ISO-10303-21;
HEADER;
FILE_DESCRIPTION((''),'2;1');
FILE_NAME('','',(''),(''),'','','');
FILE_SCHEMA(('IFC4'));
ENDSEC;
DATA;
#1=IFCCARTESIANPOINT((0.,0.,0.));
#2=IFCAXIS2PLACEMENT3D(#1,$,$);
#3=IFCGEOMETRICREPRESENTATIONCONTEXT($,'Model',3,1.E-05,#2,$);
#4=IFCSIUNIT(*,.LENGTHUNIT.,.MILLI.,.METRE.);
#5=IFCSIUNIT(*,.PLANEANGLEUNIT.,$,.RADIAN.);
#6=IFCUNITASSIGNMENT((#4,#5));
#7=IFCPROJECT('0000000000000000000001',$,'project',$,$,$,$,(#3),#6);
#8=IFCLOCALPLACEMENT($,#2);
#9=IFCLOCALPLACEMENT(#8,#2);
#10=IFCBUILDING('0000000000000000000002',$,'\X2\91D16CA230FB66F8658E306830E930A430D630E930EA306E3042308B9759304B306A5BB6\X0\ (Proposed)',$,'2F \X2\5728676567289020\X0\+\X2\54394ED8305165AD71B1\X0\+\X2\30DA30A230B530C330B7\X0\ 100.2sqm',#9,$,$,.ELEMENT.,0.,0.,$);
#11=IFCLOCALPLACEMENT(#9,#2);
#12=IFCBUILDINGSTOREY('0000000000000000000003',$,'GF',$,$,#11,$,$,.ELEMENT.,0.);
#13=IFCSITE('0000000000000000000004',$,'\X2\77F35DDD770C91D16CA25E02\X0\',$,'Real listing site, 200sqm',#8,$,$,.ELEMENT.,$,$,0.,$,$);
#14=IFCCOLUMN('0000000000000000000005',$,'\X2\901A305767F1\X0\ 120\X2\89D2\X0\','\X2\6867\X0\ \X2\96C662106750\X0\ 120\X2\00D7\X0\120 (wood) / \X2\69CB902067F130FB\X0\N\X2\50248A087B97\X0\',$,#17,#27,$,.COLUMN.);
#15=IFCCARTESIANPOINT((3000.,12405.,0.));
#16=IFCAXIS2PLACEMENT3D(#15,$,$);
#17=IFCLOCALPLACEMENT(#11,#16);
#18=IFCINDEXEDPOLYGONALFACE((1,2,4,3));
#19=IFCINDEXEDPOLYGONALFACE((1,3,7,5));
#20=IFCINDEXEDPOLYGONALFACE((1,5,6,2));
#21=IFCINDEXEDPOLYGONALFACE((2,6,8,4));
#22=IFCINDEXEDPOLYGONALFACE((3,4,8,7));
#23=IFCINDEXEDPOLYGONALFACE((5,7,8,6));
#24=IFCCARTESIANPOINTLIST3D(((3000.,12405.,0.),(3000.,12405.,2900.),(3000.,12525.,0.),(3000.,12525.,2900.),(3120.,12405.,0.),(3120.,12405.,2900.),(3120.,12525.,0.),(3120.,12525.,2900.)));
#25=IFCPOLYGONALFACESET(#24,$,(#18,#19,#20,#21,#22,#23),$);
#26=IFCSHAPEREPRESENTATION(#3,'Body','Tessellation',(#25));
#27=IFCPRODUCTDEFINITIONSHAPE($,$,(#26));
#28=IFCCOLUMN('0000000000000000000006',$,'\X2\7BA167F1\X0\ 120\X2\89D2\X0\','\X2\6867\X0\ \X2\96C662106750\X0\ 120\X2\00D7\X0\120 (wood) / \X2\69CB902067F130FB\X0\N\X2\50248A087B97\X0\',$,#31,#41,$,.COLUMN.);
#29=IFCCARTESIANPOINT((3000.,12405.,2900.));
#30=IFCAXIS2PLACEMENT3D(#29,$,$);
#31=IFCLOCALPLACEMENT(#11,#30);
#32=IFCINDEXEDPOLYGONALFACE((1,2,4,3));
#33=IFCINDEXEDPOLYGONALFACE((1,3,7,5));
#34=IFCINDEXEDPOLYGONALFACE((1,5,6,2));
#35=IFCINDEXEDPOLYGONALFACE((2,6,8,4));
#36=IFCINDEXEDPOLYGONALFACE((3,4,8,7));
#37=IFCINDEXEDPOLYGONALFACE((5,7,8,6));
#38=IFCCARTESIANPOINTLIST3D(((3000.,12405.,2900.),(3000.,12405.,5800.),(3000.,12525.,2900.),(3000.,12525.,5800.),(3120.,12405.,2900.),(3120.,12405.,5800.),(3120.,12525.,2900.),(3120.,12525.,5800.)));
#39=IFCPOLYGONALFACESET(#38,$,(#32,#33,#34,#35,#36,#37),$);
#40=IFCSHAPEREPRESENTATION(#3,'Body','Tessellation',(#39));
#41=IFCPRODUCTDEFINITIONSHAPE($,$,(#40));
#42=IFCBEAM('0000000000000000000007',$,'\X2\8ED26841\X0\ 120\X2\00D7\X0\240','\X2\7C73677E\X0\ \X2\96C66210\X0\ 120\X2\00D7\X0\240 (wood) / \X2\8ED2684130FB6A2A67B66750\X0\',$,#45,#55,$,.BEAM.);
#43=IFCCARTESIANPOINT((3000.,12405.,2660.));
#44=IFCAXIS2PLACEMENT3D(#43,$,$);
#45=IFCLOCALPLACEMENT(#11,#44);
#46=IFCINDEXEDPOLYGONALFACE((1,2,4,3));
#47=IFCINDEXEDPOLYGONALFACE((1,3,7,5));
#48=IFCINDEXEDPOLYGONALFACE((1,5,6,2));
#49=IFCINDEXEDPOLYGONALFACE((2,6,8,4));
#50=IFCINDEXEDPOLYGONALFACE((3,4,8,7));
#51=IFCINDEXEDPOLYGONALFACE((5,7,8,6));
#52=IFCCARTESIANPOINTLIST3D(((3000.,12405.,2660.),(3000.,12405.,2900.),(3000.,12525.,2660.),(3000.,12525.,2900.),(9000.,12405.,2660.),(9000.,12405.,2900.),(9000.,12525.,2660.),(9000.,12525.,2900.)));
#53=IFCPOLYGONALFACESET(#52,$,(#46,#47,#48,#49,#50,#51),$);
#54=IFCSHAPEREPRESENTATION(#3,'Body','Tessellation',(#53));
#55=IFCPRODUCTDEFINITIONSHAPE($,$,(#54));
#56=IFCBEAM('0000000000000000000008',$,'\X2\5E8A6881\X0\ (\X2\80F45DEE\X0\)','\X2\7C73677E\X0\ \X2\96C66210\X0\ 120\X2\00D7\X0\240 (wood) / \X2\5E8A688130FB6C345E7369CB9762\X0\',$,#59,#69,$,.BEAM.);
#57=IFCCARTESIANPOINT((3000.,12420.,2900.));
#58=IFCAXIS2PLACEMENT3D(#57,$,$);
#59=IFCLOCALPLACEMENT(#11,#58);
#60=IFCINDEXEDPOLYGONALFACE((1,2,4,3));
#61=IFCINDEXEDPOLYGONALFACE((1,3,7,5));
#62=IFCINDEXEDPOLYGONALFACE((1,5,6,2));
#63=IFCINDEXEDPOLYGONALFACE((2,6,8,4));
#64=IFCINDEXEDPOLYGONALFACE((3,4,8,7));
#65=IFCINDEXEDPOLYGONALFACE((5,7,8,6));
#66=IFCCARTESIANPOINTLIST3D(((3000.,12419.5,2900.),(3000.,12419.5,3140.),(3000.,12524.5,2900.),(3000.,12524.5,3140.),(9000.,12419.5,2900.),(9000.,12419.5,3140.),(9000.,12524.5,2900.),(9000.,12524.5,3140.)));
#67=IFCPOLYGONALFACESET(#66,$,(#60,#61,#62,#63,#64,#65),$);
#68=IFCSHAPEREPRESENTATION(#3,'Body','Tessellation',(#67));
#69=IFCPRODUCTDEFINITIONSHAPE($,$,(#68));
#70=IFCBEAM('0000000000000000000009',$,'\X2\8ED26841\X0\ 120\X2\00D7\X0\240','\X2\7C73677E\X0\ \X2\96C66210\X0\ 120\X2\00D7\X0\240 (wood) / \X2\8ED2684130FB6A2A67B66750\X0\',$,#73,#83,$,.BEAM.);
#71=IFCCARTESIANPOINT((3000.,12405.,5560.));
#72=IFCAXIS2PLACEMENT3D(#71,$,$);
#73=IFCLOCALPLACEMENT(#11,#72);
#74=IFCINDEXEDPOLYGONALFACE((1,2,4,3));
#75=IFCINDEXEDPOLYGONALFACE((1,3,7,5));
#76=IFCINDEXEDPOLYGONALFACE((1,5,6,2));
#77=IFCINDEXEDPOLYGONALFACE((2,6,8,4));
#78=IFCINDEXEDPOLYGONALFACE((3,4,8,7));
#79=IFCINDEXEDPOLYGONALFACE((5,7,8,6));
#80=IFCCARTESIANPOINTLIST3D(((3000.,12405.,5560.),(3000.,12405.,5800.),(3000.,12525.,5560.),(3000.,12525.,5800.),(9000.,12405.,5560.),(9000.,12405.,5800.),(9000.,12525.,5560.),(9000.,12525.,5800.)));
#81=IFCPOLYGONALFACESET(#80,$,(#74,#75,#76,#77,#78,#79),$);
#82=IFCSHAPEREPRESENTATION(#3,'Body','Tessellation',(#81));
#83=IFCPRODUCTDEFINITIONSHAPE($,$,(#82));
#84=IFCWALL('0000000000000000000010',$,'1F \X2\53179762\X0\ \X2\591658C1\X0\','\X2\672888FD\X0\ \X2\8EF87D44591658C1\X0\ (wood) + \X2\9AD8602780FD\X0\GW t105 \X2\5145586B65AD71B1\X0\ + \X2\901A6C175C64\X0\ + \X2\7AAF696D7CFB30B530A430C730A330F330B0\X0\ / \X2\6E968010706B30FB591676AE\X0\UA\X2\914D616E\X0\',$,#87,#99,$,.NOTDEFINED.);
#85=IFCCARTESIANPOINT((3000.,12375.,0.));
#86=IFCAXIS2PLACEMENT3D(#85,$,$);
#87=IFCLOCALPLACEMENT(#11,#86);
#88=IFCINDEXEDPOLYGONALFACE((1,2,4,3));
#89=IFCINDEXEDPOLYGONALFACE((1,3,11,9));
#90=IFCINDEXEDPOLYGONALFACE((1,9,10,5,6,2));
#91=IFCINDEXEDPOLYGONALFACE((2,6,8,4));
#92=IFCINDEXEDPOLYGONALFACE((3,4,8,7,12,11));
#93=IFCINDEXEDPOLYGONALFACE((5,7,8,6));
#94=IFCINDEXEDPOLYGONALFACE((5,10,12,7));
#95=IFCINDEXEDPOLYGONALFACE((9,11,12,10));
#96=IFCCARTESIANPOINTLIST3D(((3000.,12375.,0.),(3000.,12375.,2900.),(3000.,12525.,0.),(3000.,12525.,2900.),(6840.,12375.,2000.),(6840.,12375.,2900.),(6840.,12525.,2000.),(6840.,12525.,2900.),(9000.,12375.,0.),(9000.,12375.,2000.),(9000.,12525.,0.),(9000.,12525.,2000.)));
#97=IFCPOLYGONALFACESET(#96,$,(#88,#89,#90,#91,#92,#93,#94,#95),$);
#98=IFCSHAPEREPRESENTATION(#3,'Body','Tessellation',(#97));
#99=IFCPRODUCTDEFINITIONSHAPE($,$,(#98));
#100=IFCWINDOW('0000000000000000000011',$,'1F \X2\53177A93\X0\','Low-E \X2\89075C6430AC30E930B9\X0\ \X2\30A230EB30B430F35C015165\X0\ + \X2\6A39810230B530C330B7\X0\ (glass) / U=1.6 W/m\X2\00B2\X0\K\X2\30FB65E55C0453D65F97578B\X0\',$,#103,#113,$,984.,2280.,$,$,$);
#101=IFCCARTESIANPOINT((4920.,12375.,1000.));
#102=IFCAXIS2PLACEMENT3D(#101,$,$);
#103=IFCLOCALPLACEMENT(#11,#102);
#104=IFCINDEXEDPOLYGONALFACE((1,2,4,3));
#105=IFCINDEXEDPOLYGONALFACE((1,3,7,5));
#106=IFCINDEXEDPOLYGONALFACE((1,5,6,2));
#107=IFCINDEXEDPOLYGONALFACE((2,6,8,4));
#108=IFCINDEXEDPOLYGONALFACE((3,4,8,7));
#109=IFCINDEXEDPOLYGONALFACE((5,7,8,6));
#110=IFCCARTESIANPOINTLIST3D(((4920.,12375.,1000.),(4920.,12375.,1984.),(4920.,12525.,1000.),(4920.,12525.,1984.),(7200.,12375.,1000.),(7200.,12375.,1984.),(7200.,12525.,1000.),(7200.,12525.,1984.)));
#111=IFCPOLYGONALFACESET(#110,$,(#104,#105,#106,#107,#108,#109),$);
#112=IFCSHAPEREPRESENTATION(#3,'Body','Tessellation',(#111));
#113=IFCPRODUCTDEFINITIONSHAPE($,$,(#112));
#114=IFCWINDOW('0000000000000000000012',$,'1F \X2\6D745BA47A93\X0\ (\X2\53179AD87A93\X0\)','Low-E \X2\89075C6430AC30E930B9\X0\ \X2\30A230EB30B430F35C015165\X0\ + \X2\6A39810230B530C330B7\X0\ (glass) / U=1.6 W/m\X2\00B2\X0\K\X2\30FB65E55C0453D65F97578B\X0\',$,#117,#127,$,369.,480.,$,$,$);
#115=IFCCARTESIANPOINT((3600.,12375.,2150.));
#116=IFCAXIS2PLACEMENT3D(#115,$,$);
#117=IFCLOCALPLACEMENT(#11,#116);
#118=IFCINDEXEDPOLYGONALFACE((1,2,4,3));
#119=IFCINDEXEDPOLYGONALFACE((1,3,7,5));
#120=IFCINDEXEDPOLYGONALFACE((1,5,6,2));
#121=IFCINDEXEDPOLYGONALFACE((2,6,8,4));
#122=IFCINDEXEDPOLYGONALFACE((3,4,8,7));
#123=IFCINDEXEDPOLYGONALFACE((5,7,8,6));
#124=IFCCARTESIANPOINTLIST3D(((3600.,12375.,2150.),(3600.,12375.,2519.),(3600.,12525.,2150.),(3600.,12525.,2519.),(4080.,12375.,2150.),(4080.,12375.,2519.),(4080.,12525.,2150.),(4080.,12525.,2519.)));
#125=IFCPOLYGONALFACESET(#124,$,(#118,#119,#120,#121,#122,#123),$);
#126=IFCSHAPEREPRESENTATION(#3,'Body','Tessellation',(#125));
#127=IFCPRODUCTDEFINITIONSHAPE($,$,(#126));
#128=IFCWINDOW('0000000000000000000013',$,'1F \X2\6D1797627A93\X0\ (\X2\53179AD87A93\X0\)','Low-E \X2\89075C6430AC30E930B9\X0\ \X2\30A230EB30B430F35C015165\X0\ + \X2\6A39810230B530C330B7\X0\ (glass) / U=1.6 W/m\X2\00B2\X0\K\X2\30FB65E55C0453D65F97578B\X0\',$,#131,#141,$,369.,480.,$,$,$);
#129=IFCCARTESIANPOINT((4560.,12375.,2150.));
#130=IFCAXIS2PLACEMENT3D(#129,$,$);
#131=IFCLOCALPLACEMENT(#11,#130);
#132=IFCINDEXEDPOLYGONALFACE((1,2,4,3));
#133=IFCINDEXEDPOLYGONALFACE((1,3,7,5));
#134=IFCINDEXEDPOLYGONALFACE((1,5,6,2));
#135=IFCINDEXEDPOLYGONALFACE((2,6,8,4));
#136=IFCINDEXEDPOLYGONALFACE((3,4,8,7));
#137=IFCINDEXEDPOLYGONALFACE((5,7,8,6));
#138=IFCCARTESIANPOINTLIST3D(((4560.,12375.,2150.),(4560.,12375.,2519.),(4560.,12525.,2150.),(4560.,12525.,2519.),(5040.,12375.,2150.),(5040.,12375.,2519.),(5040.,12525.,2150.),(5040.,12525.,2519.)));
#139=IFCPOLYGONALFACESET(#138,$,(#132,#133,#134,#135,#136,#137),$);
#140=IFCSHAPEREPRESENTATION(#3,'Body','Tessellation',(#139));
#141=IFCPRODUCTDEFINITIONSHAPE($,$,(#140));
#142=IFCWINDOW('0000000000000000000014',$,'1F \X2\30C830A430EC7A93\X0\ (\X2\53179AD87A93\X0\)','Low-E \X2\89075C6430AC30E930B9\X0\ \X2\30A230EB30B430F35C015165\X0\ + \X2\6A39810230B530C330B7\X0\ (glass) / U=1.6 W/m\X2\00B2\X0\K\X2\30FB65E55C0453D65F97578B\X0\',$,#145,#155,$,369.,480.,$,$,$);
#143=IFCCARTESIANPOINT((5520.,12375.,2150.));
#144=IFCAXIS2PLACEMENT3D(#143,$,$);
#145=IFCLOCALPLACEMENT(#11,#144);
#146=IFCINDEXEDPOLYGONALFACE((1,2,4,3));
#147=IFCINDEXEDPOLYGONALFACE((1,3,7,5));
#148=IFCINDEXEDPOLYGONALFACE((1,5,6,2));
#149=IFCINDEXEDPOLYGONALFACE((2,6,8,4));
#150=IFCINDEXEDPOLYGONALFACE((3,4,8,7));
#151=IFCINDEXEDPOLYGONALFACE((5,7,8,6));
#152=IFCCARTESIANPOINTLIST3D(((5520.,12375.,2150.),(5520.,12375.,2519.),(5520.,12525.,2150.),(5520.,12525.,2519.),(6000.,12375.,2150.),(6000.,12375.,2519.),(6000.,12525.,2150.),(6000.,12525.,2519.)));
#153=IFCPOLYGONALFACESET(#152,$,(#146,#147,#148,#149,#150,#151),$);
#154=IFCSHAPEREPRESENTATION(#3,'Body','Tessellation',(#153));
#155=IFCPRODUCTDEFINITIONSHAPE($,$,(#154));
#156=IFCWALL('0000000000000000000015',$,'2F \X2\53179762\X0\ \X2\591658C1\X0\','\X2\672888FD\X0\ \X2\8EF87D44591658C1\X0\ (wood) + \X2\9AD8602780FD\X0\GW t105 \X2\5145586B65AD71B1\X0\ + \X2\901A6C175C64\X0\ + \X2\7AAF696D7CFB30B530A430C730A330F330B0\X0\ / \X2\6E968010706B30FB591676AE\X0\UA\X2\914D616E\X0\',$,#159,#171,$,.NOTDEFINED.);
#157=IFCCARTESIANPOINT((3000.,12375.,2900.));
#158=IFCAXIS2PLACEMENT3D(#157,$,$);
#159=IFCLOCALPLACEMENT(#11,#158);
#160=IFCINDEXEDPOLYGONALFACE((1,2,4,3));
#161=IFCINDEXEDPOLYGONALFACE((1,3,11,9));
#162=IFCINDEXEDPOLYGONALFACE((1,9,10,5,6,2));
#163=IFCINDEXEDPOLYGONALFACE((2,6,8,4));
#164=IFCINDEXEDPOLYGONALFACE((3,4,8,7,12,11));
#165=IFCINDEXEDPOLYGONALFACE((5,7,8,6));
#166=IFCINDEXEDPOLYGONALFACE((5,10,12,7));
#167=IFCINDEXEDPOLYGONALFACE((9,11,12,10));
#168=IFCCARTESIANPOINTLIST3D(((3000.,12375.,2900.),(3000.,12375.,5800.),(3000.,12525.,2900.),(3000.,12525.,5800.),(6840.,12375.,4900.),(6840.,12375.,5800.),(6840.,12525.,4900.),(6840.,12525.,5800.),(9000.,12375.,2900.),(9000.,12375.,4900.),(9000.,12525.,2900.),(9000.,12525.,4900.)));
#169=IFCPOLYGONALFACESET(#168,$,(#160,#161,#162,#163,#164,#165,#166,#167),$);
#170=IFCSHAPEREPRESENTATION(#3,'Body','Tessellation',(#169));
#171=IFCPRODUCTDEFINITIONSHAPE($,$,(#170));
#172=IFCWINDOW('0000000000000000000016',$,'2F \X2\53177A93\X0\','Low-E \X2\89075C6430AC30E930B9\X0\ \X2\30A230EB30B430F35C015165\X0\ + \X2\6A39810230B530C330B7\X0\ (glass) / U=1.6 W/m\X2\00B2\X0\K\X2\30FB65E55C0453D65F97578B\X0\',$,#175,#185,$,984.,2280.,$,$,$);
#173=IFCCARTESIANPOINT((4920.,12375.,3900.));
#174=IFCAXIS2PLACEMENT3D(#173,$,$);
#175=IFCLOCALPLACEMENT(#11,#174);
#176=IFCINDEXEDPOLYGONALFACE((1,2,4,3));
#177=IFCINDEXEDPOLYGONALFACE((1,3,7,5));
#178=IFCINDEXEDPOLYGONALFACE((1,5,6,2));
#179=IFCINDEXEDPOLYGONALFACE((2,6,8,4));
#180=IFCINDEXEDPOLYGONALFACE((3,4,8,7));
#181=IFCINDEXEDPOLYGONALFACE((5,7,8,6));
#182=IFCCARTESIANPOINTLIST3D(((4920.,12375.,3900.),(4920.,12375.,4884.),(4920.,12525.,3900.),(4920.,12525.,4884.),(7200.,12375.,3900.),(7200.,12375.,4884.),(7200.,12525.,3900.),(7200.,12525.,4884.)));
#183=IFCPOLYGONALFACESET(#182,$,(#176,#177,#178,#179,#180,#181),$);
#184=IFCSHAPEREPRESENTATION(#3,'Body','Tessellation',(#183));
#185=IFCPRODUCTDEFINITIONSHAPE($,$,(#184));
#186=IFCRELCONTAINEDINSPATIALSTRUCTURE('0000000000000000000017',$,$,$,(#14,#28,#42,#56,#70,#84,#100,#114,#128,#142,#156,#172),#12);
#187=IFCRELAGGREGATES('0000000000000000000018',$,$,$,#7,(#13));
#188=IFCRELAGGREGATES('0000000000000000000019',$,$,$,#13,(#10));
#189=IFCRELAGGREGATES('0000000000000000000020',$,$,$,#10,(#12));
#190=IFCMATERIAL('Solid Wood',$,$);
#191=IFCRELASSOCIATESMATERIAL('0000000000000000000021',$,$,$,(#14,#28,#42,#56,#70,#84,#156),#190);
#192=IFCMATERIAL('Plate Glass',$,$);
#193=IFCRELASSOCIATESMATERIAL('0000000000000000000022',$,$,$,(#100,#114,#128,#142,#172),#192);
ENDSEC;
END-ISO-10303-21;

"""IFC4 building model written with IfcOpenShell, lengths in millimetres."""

from ifc_helpers import new_model, si_unit, frame, frame_2d, origin, place, context, project, spatial, rectangle, extrude, material, element, fill, save


model = new_model("IFC4")

# Units and contexts
model_context = context("Model", 3, precision=1e-05, world=origin())
ifc_project = project(units=[si_unit("LENGTHUNIT", "METRE", prefix="MILLI"), si_unit("PLANEANGLEUNIT", "RADIAN")], contexts=[model_context])

# Site, building, storey
site_placement = place(None, origin())
site = spatial("IfcSite", under=ifc_project, at=site_placement, Name="石川県金沢市", ObjectType="Real listing site, 200sqm", CompositionType="ELEMENT", RefElevation=0.0)
building_placement = place(site_placement, origin())
building = spatial("IfcBuilding", under=site, at=building_placement, Name="金沢・書斎とライブラリのある静かな家 (Proposed)", ObjectType="2F 在来木造+吹付け断熱+ペアサッシ 100.2sqm", CompositionType="ELEMENT", ElevationOfRefHeight=0.0, ElevationOfTerrain=0.0)
storey_placement = place(building_placement, origin())
storey = spatial("IfcBuildingStorey", under=building, at=storey_placement, Name="GF", CompositionType="ELEMENT", Elevation=0.0)

# Columns
ifc_material_1 = material(Name="Solid Wood")
column_1_placement = place(storey_placement, frame((3000.0, 12405.0, 0.0)))
element("IfcColumn", 1, at=column_1_placement, inside=storey, material=ifc_material_1, Name="通し柱 120角", Description="桧 集成材 120×120 (wood) / 構造柱・N値計算", PredefinedType="COLUMN", context=model_context, shape_type="SweptSolid", body=[
    extrude(rectangle(XDim=120.0, YDim=120.0, at=frame_2d((60.0, 60.0))), frame((3000.0, 12405.0, 0.0)), (0.0, 0.0, 1.0), 2900.0),
])
column_2_placement = place(storey_placement, frame((3000.0, 12405.0, 2900.0)))
element("IfcColumn", 2, at=column_2_placement, inside=storey, material=ifc_material_1, Name="管柱 120角", Description="桧 集成材 120×120 (wood) / 構造柱・N値計算", PredefinedType="COLUMN", context=model_context, shape_type="SweptSolid", body=[
    extrude(rectangle(XDim=120.0, YDim=120.0, at=frame_2d((60.0, 60.0))), frame((3000.0, 12405.0, 2900.0)), (0.0, 0.0, 1.0), 2900.0),
])

# Beams
beam_1_placement = place(storey_placement, frame((3000.0, 12405.0, 2660.0)))
element("IfcBeam", 3, at=beam_1_placement, inside=storey, material=ifc_material_1, Name="軒桁 120×240", Description="米松 集成 120×240 (wood) / 軒桁・横架材", PredefinedType="BEAM", context=model_context, shape_type="SweptSolid", body=[
    extrude(rectangle(XDim=6000.0, YDim=120.0, at=frame_2d((3000.0, 60.0))), frame((3000.0, 12405.0, 2660.0)), (0.0, 0.0, 1.0), 240.0),
])
beam_2_placement = place(storey_placement, frame((3000.0, 12420.0, 2900.0)))
element("IfcBeam", 4, at=beam_2_placement, inside=storey, material=ifc_material_1, Name="床梁 (胴差)", Description="米松 集成 120×240 (wood) / 床梁・水平構面", PredefinedType="BEAM", context=model_context, shape_type="SweptSolid", body=[
    extrude(rectangle(XDim=6000.0, YDim=105.0, at=frame_2d((3000.0, 52.0))), frame((3000.0, 12420.0, 2900.0)), (0.0, 0.0, 1.0), 240.0),
])
beam_3_placement = place(storey_placement, frame((3000.0, 12405.0, 5560.0)))
element("IfcBeam", 5, at=beam_3_placement, inside=storey, material=ifc_material_1, Name="軒桁 120×240", Description="米松 集成 120×240 (wood) / 軒桁・横架材", PredefinedType="BEAM", context=model_context, shape_type="SweptSolid", body=[
    extrude(rectangle(XDim=6000.0, YDim=120.0, at=frame_2d((3000.0, 60.0))), frame((3000.0, 12405.0, 5560.0)), (0.0, 0.0, 1.0), 240.0),
])

# Wall, openings, windows
wall_1_placement = place(storey_placement, frame((3000.0, 12375.0, 0.0)))
wall_1 = element("IfcWall", 6, at=wall_1_placement, inside=storey, material=ifc_material_1, Name="1F 北面 外壁", Description="木製 軸組外壁 (wood) + 高性能GW t105 充填断熱 + 通気層 + 窯業系サイディング / 準耐火・外皮UA配慮", PredefinedType="NOTDEFINED", context=model_context, shape_type="SweptSolid", body=[
    extrude(rectangle(XDim=6000.0, YDim=150.0, at=frame_2d((3000.0, 75.0))), frame((3000.0, 12375.0, 0.0)), (0.0, 0.0, 1.0), 2900.0),
])
opening_1_placement = place(storey_placement, frame((4920.0, 12375.0, 1000.0)))
opening_1 = element("IfcOpeningElement", 7, at=opening_1_placement, cuts=wall_1, PredefinedType="NOTDEFINED", context=model_context, shape_type="SweptSolid", body=[
    extrude(rectangle(XDim=2280.0, YDim=150.0, at=frame_2d((1140.0, 75.0))), frame((4920.0, 12375.0, 1000.0)), (0.0, 0.0, 1.0), 984.0),
])
opening_2_placement = place(storey_placement, frame((3600.0, 12375.0, 2150.0)))
opening_2 = element("IfcOpeningElement", 8, at=opening_2_placement, cuts=wall_1, PredefinedType="NOTDEFINED", context=model_context, shape_type="SweptSolid", body=[
    extrude(rectangle(XDim=480.0, YDim=150.0, at=frame_2d((240.0, 75.0))), frame((3600.0, 12375.0, 2150.0)), (0.0, 0.0, 1.0), 369.0),
])
opening_3_placement = place(storey_placement, frame((4560.0, 12375.0, 2150.0)))
opening_3 = element("IfcOpeningElement", 9, at=opening_3_placement, cuts=wall_1, PredefinedType="NOTDEFINED", context=model_context, shape_type="SweptSolid", body=[
    extrude(rectangle(XDim=480.0, YDim=150.0, at=frame_2d((240.0, 75.0))), frame((4560.0, 12375.0, 2150.0)), (0.0, 0.0, 1.0), 369.0),
])
opening_4_placement = place(storey_placement, frame((5520.0, 12375.0, 2150.0)))
opening_4 = element("IfcOpeningElement", 10, at=opening_4_placement, cuts=wall_1, PredefinedType="NOTDEFINED", context=model_context, shape_type="SweptSolid", body=[
    extrude(rectangle(XDim=480.0, YDim=150.0, at=frame_2d((240.0, 75.0))), frame((5520.0, 12375.0, 2150.0)), (0.0, 0.0, 1.0), 369.0),
])
ifc_material_2 = material(Name="Plate Glass")
window_1_placement = place(storey_placement, frame((4920.0, 12375.0, 1000.0)))
window_1 = element("IfcWindow", 11, at=window_1_placement, inside=storey, material=ifc_material_2, Name="1F 北窓", Description="Low-E 複層ガラス アルゴン封入 + 樹脂サッシ (glass) / U=1.6 W/m²K・日射取得型", OverallHeight=984.0, OverallWidth=2280.0, context=model_context, shape_type="SweptSolid", body=[
    extrude(rectangle(XDim=2280.0, YDim=150.0, at=frame_2d((1140.0, 75.0))), frame((4920.0, 12375.0, 1000.0)), (0.0, 0.0, 1.0), 984.0),
])
fill(opening_1, window_1)
window_2_placement = place(storey_placement, frame((3600.0, 12375.0, 2150.0)))
window_2 = element("IfcWindow", 12, at=window_2_placement, inside=storey, material=ifc_material_2, Name="1F 浴室窓 (北高窓)", Description="Low-E 複層ガラス アルゴン封入 + 樹脂サッシ (glass) / U=1.6 W/m²K・日射取得型", OverallHeight=369.0, OverallWidth=480.0, context=model_context, shape_type="SweptSolid", body=[
    extrude(rectangle(XDim=480.0, YDim=150.0, at=frame_2d((240.0, 75.0))), frame((3600.0, 12375.0, 2150.0)), (0.0, 0.0, 1.0), 369.0),
])
fill(opening_2, window_2)
window_3_placement = place(storey_placement, frame((4560.0, 12375.0, 2150.0)))
window_3 = element("IfcWindow", 13, at=window_3_placement, inside=storey, material=ifc_material_2, Name="1F 洗面窓 (北高窓)", Description="Low-E 複層ガラス アルゴン封入 + 樹脂サッシ (glass) / U=1.6 W/m²K・日射取得型", OverallHeight=369.0, OverallWidth=480.0, context=model_context, shape_type="SweptSolid", body=[
    extrude(rectangle(XDim=480.0, YDim=150.0, at=frame_2d((240.0, 75.0))), frame((4560.0, 12375.0, 2150.0)), (0.0, 0.0, 1.0), 369.0),
])
fill(opening_3, window_3)
window_4_placement = place(storey_placement, frame((5520.0, 12375.0, 2150.0)))
window_4 = element("IfcWindow", 14, at=window_4_placement, inside=storey, material=ifc_material_2, Name="1F トイレ窓 (北高窓)", Description="Low-E 複層ガラス アルゴン封入 + 樹脂サッシ (glass) / U=1.6 W/m²K・日射取得型", OverallHeight=369.0, OverallWidth=480.0, context=model_context, shape_type="SweptSolid", body=[
    extrude(rectangle(XDim=480.0, YDim=150.0, at=frame_2d((240.0, 75.0))), frame((5520.0, 12375.0, 2150.0)), (0.0, 0.0, 1.0), 369.0),
])
fill(opening_4, window_4)

# Wall, opening, window
wall_2_placement = place(storey_placement, frame((3000.0, 12375.0, 2900.0)))
wall_2 = element("IfcWall", 15, at=wall_2_placement, inside=storey, material=ifc_material_1, Name="2F 北面 外壁", Description="木製 軸組外壁 (wood) + 高性能GW t105 充填断熱 + 通気層 + 窯業系サイディング / 準耐火・外皮UA配慮", PredefinedType="NOTDEFINED", context=model_context, shape_type="SweptSolid", body=[
    extrude(rectangle(XDim=6000.0, YDim=150.0, at=frame_2d((3000.0, 75.0))), frame((3000.0, 12375.0, 2900.0)), (0.0, 0.0, 1.0), 2900.0),
])
opening_5_placement = place(storey_placement, frame((4920.0, 12375.0, 3900.0)))
opening_5 = element("IfcOpeningElement", 16, at=opening_5_placement, cuts=wall_2, PredefinedType="NOTDEFINED", context=model_context, shape_type="SweptSolid", body=[
    extrude(rectangle(XDim=2280.0, YDim=150.0, at=frame_2d((1140.0, 75.0))), frame((4920.0, 12375.0, 3900.0)), (0.0, 0.0, 1.0), 984.0),
])
window_5_placement = place(storey_placement, frame((4920.0, 12375.0, 3900.0)))
window_5 = element("IfcWindow", 17, at=window_5_placement, inside=storey, material=ifc_material_2, Name="2F 北窓", Description="Low-E 複層ガラス アルゴン封入 + 樹脂サッシ (glass) / U=1.6 W/m²K・日射取得型", OverallHeight=984.0, OverallWidth=2280.0, context=model_context, shape_type="SweptSolid", body=[
    extrude(rectangle(XDim=2280.0, YDim=150.0, at=frame_2d((1140.0, 75.0))), frame((4920.0, 12375.0, 3900.0)), (0.0, 0.0, 1.0), 984.0),
])
fill(opening_5, window_5)

save(model, "model.ifc")
